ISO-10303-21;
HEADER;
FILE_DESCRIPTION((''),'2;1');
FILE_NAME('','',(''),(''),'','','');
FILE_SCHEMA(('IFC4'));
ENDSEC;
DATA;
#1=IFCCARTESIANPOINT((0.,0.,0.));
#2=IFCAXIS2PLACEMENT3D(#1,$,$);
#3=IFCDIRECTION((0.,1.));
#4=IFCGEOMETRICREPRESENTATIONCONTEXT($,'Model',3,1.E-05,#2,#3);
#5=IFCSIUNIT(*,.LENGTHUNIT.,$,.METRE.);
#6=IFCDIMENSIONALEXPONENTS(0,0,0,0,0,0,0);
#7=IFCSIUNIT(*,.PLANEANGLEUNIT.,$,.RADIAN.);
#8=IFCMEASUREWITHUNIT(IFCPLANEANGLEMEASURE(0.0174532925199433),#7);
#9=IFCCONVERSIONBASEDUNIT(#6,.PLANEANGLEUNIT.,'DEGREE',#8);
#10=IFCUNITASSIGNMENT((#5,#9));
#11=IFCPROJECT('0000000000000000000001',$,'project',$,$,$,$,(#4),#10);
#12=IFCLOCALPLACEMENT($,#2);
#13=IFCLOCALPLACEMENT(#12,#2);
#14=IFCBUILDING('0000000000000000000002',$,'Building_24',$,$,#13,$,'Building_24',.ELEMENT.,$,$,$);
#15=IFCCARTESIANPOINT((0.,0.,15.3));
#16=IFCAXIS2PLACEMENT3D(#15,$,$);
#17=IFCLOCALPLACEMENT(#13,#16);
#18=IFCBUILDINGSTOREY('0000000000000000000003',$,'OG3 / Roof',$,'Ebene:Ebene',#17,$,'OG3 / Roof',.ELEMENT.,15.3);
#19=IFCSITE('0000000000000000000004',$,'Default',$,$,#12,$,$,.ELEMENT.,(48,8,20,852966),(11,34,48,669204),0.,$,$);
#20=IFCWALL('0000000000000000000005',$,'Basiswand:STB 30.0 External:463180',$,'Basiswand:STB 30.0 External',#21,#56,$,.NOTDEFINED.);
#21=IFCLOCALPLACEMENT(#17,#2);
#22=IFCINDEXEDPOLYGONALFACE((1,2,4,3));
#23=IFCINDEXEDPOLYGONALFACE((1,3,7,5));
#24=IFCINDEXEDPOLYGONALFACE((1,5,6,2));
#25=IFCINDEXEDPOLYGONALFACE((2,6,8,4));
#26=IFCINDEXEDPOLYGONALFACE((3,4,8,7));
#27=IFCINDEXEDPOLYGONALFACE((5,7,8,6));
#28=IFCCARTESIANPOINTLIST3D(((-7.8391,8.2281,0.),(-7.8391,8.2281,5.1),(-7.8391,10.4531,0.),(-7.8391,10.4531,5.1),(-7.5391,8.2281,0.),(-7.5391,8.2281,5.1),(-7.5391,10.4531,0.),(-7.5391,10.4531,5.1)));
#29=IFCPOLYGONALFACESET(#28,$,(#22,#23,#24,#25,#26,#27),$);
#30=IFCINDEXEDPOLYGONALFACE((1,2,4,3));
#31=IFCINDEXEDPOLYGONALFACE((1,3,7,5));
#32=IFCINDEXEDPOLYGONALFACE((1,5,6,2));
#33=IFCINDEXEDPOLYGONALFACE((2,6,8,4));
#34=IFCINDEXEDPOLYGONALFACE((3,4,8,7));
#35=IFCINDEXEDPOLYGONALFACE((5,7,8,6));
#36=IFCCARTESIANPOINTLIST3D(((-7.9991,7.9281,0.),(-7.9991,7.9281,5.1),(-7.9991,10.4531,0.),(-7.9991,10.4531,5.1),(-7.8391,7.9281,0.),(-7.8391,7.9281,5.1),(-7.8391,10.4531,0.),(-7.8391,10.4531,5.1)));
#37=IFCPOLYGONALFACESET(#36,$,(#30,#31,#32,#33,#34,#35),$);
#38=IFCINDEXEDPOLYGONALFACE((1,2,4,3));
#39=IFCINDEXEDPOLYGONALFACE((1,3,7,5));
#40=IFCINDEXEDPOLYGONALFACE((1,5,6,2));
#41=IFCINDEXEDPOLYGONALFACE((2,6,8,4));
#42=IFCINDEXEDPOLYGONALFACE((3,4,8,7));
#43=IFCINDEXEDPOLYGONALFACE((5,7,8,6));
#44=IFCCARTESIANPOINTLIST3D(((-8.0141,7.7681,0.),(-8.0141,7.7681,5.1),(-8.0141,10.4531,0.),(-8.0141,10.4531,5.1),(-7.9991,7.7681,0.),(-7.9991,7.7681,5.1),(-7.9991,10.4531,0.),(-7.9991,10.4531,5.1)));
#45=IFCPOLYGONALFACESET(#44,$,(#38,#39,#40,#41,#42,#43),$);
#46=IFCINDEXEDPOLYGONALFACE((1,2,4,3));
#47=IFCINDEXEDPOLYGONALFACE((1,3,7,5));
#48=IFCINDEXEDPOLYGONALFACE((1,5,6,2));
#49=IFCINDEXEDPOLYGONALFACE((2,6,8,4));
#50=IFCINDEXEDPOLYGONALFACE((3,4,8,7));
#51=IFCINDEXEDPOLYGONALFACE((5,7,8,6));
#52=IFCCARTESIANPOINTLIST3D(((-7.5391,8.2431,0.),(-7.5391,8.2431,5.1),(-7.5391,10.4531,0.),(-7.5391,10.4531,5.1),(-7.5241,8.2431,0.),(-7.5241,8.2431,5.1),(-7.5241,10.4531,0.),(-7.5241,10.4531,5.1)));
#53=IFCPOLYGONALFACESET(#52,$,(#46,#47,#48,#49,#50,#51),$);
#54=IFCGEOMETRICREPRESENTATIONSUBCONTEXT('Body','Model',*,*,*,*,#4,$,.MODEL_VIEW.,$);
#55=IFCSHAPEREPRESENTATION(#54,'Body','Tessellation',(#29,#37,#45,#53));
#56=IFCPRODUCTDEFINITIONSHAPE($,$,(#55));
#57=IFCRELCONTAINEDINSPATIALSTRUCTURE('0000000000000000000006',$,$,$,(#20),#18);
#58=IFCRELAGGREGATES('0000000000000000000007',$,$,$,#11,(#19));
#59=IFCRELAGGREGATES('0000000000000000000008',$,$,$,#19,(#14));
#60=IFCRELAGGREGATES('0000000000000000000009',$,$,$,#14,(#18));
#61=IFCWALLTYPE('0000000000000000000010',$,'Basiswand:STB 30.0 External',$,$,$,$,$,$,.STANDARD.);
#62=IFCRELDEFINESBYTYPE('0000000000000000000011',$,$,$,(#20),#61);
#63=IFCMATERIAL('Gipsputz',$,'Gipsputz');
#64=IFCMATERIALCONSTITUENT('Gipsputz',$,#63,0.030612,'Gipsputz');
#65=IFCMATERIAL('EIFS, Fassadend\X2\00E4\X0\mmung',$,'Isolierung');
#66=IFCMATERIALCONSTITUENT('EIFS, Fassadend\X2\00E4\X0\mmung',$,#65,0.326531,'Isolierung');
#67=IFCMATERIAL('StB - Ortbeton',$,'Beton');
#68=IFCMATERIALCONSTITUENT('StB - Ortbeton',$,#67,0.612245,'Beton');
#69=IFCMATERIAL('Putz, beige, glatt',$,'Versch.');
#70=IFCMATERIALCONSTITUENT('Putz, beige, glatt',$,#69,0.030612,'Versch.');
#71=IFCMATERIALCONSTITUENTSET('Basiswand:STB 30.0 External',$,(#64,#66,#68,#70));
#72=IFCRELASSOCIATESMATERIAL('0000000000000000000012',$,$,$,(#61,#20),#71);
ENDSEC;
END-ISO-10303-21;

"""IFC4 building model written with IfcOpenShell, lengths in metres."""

from ifc_helpers import new_model, entity, si_unit, converted_unit, direction, frame, origin, place, context, subcontext, project, spatial, indexed_curve, outline, extrude, material, constituent, constituent_set, type_object, element, save


model = new_model("IFC4")

# Units and contexts
model_context = context("Model", 3, precision=1e-05, world=origin(), true_north=direction((0.0, 1.0)))
body_context = subcontext(model_context, "Body", "Model", "MODEL_VIEW")
ifc_project = project(units=[si_unit("LENGTHUNIT", "METRE"), converted_unit("PLANEANGLEUNIT", "DEGREE", entity("IfcPlaneAngleMeasure", 0.0174532925199433), si_unit("PLANEANGLEUNIT", "RADIAN"), dimensions=[0, 0, 0, 0, 0, 0, 0])], contexts=[model_context])

# Site, building, storey
site_placement = place(None, origin())
site = spatial("IfcSite", under=ifc_project, at=site_placement, Name="Default", CompositionType="ELEMENT", RefLatitude=(48, 8, 20, 852966), RefLongitude=(11, 34, 48, 669204), RefElevation=0.0)
building_placement = place(site_placement, origin())
building = spatial("IfcBuilding", under=site, at=building_placement, Name="Building_24", LongName="Building_24", CompositionType="ELEMENT")
storey_placement = place(building_placement, frame((0.0, 0.0, 15.3)))
storey = spatial("IfcBuildingStorey", under=building, at=storey_placement, Name="OG3 / Roof", ObjectType="Ebene:Ebene", LongName="OG3 / Roof", CompositionType="ELEMENT", Elevation=15.3)

# Shared definitions
ifc_material_1 = material(Name="StB - Ortbeton", Category="Beton")

# Wall
ifc_material_2 = material(Name="Gipsputz", Category="Gipsputz")
ifc_constituent_1 = constituent(ifc_material_2, Name="Gipsputz", Category="Gipsputz", fraction=0.030612)
ifc_material_3 = material(Name="EIFS, Fassadendämmung", Category="Isolierung")
ifc_constituent_2 = constituent(ifc_material_3, Name="EIFS, Fassadendämmung", Category="Isolierung", fraction=0.326531)
ifc_constituent_3 = constituent(ifc_material_1, Name="StB - Ortbeton", Category="Beton", fraction=0.612245)
ifc_material_4 = material(Name="Putz, beige, glatt", Category="Versch.")
ifc_constituent_4 = constituent(ifc_material_4, Name="Putz, beige, glatt", Category="Versch.", fraction=0.030612)
ifc_constituent_set_1 = constituent_set(constituents=[ifc_constituent_1, ifc_constituent_2, ifc_constituent_3, ifc_constituent_4], Name="Basiswand:STB 30.0 External")
wall_type = type_object("IfcWallType", Name="Basiswand:STB 30.0 External", PredefinedType="STANDARD", material=ifc_constituent_set_1)
wall_1_placement = place(storey_placement, frame((-7.7691, 10.4531, 0.0), z_axis=(0.0, 0.0, 1.0), x_axis=(0.0, -1.0, 0.0)))
element("IfcWall", 1, at=wall_1_placement, inside=storey, type_object=wall_type, material=ifc_constituent_set_1, Name="Basiswand:STB 30.0 External:463180", ObjectType="Basiswand:STB 30.0 External", PredefinedType="NOTDEFINED", context=body_context, shape_type="SweptSolid", body=[
    extrude(outline(indexed_curve([(-1.1125, -0.15), (1.1125, -0.15), (1.1125, 0.15), (-1.1125, 0.15), (-1.1125, -0.15)], self_intersect=False)), frame((1.1125, 0.08, 0.0)), (0.0, 0.0, 1.0), 5.1),
    extrude(outline(indexed_curve([(-1.2625, -0.08), (1.2625, -0.08), (1.2625, 0.08), (-1.2625, 0.08), (-1.2625, -0.08)], self_intersect=False)), frame((1.2625, -0.15, 0.0)), (0.0, 0.0, 1.0), 5.1),
    extrude(outline(indexed_curve([(-0.0075, -1.3425), (0.0075, -1.3425), (0.0075, 1.3425), (-0.0075, 1.3425), (-0.0075, -1.3425)], self_intersect=False)), frame((1.3425, -0.2375, 0.0), z_axis=(0.0, 0.0, 1.0), x_axis=(0.0, 1.0, 0.0)), (0.0, 0.0, 1.0), 5.1),
    extrude(outline(indexed_curve([(-0.0075, -1.105), (0.0075, -1.105), (0.0075, 1.105), (-0.0075, 1.105), (-0.0075, -1.105)], self_intersect=False)), frame((1.105, 0.2375, 0.0), z_axis=(0.0, 0.0, 1.0), x_axis=(0.0, -1.0, 0.0)), (0.0, 0.0, 1.0), 5.1),
])

save(model, "model.ifc")
